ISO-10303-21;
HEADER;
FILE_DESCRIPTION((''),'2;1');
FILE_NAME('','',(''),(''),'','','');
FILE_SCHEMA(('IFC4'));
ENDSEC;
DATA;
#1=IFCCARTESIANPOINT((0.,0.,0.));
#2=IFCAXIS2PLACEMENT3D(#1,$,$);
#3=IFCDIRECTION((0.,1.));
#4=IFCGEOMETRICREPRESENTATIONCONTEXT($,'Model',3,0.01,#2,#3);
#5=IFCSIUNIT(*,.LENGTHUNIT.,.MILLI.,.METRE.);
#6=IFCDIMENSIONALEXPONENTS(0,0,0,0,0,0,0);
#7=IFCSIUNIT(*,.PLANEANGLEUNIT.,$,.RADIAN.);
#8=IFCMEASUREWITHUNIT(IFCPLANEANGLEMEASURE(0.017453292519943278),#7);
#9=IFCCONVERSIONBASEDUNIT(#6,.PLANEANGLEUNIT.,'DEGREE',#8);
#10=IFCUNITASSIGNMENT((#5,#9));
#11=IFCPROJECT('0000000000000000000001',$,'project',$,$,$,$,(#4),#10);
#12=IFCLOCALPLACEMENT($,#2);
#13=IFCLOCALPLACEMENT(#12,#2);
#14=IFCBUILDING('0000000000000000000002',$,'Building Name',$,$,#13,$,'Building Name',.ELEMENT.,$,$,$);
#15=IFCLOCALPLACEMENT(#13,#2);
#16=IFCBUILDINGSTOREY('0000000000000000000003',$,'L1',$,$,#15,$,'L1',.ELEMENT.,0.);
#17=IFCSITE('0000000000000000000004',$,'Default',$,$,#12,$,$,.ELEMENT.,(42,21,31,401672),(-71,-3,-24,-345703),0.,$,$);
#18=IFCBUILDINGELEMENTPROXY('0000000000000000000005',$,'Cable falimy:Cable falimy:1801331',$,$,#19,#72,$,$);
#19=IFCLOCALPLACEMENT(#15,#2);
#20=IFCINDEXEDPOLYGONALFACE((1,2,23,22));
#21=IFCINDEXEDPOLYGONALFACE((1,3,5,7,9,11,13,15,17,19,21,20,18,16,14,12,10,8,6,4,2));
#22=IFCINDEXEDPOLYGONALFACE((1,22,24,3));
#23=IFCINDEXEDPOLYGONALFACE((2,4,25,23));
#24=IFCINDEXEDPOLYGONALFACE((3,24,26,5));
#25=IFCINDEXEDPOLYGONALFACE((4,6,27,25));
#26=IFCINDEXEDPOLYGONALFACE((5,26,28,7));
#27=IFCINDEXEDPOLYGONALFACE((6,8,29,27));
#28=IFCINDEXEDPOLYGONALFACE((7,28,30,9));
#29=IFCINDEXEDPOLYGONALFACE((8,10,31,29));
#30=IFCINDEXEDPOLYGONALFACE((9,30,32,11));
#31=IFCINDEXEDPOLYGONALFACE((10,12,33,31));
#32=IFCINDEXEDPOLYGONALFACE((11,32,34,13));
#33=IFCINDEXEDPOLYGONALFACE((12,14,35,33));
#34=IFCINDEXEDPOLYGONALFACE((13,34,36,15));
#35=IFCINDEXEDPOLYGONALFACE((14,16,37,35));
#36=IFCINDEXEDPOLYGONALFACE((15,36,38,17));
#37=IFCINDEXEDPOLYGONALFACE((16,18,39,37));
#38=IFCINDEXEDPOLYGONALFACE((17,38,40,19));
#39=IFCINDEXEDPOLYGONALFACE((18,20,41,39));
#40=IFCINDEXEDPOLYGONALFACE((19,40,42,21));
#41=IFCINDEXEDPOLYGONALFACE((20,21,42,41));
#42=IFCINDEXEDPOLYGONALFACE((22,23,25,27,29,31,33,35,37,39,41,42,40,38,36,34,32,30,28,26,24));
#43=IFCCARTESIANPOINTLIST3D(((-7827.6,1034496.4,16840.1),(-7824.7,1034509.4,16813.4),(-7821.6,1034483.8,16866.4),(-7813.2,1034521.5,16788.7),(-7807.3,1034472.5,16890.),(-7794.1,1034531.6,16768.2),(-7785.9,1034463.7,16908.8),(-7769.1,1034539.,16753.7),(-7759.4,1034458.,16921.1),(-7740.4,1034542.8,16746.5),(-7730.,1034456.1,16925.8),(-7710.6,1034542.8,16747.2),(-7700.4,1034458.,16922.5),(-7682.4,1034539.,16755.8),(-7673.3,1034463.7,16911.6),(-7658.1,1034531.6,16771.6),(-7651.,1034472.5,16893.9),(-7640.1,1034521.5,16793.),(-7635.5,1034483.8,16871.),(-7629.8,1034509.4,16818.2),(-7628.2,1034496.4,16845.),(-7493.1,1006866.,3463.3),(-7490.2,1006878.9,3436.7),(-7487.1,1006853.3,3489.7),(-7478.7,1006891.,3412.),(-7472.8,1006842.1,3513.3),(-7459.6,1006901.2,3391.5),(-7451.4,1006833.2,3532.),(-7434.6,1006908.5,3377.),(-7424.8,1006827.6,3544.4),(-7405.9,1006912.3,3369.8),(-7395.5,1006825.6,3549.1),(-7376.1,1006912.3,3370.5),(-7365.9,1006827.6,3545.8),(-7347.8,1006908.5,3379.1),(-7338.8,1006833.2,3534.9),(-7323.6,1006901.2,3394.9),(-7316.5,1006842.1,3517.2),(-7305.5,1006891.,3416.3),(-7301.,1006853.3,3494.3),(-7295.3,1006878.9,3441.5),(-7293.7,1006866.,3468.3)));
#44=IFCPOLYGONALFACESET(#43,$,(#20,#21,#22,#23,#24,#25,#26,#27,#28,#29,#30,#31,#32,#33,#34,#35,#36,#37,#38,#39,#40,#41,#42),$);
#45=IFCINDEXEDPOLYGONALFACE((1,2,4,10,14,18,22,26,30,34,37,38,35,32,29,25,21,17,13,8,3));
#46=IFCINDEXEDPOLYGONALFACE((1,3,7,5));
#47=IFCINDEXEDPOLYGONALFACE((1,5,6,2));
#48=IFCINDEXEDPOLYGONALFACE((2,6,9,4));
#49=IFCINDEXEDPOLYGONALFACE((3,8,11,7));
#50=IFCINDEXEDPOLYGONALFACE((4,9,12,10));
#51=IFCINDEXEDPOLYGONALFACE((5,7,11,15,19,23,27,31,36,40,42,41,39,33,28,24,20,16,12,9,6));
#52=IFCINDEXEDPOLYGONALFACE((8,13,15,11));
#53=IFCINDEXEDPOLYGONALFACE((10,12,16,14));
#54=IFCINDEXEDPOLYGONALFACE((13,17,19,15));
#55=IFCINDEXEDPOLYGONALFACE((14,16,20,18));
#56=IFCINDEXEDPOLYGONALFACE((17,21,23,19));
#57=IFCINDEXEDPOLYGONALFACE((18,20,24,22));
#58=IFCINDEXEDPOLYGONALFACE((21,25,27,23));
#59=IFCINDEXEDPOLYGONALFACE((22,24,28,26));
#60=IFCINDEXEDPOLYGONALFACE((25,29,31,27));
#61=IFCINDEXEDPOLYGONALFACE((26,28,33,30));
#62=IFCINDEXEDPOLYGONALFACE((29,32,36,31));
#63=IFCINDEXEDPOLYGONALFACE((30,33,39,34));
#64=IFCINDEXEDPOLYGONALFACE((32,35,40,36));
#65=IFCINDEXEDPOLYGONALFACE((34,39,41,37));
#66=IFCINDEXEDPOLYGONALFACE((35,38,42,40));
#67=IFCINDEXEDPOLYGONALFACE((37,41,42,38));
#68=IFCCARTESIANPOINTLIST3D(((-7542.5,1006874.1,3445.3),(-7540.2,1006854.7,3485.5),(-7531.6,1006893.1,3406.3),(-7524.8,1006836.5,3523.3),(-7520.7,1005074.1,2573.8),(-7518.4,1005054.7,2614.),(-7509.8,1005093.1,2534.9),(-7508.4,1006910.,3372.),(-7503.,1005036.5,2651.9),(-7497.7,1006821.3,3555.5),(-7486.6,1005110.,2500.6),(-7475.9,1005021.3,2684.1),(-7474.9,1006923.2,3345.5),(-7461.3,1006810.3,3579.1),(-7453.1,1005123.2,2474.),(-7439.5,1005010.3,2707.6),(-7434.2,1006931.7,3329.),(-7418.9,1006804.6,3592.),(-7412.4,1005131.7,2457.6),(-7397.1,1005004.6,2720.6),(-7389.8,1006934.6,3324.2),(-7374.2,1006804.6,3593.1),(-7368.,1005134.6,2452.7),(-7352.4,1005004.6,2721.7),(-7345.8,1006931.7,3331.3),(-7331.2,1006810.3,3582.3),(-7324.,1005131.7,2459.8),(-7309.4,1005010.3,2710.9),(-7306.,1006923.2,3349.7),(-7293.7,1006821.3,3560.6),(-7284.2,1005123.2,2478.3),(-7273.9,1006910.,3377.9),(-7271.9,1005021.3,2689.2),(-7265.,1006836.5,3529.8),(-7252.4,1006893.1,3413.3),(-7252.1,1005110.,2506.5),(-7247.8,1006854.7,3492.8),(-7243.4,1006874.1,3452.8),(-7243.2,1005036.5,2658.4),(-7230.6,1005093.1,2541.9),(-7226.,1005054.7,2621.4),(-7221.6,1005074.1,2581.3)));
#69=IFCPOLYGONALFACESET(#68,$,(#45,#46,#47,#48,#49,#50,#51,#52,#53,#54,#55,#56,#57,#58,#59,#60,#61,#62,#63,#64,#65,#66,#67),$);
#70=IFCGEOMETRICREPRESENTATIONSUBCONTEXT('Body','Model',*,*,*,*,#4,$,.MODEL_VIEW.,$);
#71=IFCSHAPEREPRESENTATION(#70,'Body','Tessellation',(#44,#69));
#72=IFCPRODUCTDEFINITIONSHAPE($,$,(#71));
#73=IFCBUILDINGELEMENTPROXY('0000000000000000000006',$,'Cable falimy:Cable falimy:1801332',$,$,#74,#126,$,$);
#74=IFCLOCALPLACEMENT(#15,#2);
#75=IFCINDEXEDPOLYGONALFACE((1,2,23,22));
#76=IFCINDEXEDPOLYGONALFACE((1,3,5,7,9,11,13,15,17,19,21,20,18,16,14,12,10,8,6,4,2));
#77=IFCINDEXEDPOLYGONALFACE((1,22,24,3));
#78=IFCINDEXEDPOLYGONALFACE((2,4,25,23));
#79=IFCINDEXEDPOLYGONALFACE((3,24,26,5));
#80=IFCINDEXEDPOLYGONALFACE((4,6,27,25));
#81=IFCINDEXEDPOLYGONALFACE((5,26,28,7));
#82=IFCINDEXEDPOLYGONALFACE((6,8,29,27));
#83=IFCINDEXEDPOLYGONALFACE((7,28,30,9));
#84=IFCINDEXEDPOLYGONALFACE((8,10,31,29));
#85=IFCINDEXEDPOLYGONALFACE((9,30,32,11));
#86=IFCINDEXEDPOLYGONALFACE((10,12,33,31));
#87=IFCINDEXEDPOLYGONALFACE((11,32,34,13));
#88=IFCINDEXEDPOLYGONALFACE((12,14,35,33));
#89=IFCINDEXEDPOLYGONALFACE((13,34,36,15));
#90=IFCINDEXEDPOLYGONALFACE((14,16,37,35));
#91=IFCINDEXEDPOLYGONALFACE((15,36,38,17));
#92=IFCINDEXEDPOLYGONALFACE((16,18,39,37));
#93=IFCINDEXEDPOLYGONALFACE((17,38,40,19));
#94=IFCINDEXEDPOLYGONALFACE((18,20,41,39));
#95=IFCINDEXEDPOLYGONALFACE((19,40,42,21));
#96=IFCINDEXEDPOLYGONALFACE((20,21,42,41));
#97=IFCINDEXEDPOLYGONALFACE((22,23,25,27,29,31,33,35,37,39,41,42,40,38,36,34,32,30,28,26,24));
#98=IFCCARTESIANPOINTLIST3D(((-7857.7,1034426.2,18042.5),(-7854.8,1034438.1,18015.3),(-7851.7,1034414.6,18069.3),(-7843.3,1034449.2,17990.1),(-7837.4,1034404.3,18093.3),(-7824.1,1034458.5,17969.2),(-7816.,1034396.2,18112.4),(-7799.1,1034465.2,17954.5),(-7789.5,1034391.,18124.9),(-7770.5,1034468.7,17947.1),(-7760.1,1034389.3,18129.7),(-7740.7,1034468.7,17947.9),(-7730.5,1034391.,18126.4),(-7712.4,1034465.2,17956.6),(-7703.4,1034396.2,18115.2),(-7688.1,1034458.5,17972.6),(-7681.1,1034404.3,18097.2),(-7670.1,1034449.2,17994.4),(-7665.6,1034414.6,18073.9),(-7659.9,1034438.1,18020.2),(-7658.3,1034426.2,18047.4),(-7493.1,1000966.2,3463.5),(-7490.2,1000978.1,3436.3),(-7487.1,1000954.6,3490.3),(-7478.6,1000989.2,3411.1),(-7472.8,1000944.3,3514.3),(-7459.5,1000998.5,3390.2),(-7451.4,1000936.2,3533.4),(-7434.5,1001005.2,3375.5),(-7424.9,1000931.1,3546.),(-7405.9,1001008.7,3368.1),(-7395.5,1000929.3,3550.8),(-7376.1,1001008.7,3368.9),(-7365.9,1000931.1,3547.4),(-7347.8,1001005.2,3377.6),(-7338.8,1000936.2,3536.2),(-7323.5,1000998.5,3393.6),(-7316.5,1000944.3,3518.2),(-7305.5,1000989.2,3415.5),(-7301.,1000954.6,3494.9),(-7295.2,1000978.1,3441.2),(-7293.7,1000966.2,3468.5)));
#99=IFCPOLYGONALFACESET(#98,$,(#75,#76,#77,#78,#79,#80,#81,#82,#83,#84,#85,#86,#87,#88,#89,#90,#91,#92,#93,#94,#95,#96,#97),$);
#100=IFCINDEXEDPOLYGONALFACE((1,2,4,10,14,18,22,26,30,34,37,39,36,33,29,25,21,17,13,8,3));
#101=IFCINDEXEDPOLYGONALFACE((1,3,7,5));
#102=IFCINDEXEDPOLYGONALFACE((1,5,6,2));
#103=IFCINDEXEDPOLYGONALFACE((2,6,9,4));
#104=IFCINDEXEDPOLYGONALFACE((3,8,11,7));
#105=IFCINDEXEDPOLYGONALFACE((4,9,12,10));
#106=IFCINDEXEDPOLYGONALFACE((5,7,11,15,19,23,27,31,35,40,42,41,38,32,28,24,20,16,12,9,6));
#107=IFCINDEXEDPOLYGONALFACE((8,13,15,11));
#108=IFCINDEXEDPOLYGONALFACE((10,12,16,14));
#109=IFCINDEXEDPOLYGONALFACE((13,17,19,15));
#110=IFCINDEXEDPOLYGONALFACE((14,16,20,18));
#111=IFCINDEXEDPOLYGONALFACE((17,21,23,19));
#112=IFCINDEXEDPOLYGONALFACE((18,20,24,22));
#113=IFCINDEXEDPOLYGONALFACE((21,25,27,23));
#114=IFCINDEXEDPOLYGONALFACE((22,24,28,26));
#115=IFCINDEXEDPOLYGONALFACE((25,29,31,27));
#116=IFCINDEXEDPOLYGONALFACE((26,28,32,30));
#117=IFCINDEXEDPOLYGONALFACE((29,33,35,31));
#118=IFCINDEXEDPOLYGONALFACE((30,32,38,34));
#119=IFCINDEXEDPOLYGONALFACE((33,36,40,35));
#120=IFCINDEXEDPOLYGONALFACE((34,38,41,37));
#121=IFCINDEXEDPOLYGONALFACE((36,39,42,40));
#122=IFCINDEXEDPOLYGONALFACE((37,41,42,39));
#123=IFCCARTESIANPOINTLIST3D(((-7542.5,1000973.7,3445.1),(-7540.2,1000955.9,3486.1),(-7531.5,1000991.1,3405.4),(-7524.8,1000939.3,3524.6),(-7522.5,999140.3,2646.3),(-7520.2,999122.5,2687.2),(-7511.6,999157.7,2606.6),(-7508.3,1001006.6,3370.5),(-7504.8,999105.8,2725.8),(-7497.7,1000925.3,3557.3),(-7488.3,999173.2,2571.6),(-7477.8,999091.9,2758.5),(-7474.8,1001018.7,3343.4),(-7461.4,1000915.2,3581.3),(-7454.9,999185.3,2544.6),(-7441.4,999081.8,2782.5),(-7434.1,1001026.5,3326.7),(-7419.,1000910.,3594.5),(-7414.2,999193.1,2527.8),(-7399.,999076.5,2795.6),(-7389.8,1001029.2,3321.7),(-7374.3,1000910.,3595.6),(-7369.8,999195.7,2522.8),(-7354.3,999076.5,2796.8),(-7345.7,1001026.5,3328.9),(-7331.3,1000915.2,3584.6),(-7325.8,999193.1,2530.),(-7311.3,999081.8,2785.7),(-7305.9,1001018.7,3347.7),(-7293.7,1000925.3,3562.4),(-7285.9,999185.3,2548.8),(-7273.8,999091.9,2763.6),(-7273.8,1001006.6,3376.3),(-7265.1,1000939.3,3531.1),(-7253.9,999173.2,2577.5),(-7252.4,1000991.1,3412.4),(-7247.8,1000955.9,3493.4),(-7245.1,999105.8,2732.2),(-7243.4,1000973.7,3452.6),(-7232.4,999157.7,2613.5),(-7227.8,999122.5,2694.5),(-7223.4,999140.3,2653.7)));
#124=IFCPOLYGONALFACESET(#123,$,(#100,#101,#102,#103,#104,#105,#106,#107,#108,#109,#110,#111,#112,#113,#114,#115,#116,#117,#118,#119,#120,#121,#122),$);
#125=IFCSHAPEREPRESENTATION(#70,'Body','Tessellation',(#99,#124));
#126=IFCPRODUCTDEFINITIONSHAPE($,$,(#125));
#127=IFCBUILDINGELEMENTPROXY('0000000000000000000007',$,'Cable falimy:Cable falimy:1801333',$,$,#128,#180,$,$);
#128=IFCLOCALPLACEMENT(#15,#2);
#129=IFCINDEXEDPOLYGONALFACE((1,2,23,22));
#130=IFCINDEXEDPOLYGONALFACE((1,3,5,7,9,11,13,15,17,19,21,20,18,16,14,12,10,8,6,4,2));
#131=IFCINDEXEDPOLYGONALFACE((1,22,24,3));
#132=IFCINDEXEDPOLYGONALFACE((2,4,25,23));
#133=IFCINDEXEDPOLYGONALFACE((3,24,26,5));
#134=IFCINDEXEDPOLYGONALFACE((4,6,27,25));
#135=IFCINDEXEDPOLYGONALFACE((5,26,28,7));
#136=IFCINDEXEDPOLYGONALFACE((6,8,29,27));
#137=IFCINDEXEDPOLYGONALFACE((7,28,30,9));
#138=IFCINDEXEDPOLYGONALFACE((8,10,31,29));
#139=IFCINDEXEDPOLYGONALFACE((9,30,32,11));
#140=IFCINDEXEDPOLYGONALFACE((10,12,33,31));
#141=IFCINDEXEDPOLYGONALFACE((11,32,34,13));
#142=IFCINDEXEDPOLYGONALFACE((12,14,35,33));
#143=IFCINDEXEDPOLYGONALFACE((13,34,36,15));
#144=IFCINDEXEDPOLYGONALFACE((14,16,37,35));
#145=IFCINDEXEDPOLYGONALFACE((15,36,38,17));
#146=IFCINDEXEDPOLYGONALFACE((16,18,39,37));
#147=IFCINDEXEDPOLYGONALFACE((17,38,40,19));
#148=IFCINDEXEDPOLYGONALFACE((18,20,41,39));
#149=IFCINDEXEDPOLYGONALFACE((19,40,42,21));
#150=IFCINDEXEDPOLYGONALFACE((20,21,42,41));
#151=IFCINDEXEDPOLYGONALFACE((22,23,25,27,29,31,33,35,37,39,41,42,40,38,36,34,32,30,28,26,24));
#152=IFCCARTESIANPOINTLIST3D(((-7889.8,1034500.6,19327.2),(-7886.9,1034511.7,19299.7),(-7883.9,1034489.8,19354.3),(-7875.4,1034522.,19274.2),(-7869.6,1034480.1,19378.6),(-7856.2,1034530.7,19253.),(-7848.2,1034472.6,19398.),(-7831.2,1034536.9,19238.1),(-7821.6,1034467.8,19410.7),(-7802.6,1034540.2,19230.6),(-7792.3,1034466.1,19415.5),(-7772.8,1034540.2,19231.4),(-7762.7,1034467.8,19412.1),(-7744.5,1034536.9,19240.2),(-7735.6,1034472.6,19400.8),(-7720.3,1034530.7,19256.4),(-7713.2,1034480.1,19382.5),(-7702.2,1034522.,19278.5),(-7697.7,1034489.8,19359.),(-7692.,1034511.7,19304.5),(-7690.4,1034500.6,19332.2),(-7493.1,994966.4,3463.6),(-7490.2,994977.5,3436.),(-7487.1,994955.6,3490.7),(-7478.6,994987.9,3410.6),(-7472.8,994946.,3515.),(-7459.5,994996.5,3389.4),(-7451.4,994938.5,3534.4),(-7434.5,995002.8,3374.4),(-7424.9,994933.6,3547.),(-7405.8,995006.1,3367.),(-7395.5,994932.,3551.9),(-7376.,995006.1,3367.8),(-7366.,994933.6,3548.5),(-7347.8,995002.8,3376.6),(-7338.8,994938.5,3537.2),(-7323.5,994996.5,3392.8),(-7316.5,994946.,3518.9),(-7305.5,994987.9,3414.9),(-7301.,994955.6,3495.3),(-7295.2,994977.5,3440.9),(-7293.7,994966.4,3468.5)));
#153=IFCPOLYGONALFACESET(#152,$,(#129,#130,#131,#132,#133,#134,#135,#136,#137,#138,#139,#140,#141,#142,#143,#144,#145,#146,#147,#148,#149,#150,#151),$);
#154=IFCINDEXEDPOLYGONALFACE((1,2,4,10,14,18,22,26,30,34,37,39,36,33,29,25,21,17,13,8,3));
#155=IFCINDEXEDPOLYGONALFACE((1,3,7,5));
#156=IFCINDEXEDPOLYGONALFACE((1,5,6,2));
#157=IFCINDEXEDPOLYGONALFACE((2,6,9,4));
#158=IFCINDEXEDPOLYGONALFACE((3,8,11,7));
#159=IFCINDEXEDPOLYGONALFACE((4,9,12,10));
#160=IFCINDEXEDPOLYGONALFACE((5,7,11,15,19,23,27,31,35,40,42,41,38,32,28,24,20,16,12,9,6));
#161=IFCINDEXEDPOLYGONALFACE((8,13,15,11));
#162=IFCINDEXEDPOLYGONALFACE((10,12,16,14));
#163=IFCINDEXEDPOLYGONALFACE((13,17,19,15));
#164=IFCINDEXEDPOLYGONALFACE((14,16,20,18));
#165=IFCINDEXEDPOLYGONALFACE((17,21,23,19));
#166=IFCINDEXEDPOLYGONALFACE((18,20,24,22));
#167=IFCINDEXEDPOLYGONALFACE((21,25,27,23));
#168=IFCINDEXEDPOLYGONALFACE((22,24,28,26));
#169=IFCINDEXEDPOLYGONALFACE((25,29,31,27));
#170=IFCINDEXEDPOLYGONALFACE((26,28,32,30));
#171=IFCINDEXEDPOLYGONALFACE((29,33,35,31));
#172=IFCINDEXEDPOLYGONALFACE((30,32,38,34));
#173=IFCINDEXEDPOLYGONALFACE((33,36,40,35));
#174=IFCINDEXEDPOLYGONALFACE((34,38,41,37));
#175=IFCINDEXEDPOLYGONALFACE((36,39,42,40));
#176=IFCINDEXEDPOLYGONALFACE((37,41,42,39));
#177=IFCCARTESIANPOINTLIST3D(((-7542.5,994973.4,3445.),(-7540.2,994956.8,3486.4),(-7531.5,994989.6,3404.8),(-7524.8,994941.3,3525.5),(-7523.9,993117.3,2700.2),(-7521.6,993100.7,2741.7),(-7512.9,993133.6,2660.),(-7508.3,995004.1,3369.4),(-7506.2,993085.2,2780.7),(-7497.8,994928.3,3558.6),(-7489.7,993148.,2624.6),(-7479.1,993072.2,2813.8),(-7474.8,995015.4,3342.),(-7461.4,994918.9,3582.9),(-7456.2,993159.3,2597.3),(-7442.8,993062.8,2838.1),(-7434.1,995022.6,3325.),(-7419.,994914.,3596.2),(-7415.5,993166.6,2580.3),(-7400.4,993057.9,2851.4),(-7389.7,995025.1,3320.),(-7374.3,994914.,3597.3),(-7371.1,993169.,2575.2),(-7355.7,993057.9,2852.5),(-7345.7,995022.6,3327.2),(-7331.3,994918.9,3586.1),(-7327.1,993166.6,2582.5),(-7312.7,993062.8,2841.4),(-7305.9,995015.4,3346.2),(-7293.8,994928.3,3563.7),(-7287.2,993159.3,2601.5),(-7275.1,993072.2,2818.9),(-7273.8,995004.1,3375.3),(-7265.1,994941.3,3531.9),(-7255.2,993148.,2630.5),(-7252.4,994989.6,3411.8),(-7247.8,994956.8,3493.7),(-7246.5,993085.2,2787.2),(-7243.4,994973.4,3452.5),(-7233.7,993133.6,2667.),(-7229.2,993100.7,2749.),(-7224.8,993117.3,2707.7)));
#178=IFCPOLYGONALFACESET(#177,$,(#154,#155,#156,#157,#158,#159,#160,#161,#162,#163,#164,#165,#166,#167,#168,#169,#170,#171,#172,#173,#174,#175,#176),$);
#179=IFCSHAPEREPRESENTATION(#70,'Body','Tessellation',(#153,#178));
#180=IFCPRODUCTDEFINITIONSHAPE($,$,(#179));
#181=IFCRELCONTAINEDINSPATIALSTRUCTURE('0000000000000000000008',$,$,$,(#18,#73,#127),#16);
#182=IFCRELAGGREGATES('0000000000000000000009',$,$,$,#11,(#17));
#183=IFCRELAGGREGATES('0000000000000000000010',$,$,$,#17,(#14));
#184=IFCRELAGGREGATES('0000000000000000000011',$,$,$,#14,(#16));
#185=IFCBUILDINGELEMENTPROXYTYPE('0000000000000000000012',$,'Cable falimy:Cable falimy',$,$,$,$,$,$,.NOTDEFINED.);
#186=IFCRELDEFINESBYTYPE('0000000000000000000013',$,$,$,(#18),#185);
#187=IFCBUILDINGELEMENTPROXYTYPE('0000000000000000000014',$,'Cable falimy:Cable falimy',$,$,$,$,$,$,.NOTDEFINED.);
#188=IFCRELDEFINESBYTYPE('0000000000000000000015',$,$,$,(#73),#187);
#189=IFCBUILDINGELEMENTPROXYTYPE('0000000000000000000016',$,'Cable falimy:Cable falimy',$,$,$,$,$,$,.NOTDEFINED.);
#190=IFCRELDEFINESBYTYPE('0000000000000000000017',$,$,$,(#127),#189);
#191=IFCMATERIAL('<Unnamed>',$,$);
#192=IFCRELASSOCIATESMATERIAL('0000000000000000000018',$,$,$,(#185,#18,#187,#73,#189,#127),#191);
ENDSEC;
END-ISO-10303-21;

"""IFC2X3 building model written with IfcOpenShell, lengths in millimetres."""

from ifc_helpers import new_model, entity, si_unit, converted_unit, direction, frame, frame_2d, origin, place, context, subcontext, project, spatial, circle, extrude, source, transform, mapped, material, type_object, type_shapes, element, save


model = new_model("IFC2X3")

# Units and contexts
model_context = context("Model", 3, precision=0.01, world=origin(), true_north=direction((0.0, 1.0)))
body_context = subcontext(model_context, "Body", "Model", "MODEL_VIEW")
ifc_project = project(units=[si_unit("LENGTHUNIT", "METRE", prefix="MILLI"), converted_unit("PLANEANGLEUNIT", "DEGREE", entity("IfcPlaneAngleMeasure", 0.017453292519943278), si_unit("PLANEANGLEUNIT", "RADIAN"), dimensions=[0, 0, 0, 0, 0, 0, 0])], contexts=[model_context])

# Site, building, storey
site_placement = place(None, origin())
site = spatial("IfcSite", under=ifc_project, at=site_placement, Name="Default", CompositionType="ELEMENT", RefLatitude=(42, 21, 31, 401672), RefLongitude=(-71, -3, -24, -345703), RefElevation=0.0)
building_placement = place(site_placement, origin())
building = spatial("IfcBuilding", under=site, at=building_placement, Name="Building Name", LongName="Building Name", CompositionType="ELEMENT")
storey_placement = place(building_placement, origin())
storey = spatial("IfcBuildingStorey", under=building, at=storey_placement, Name="L1", LongName="L1", CompositionType="ELEMENT", Elevation=0.0)

# Shared definitions
ifc_material = material(Name="<Unnamed>")

# Building element proxies
building_element_proxy_type_1 = type_object("IfcBuildingElementProxyType", Name="Cable falimy:Cable falimy", PredefinedType="NOTDEFINED", material=ifc_material)
shared_shape_1 = source(origin(), body_context, "Body", "SweptSolid", [
    extrude(circle(Radius=100.0, at=frame_2d((0.0, 0.0), x_axis=(1.0, 0.0))), frame((0.0, 0.0, 0.0), z_axis=(0.900015, 0.0, 0.43586), x_axis=(-0.43586, 0.0, 0.900015)), (0.0, 0.0, 1.0), 30700.0),
    extrude(circle(Radius=150.0, at=frame_2d((0.0, 0.0), x_axis=(1.0, 0.0))), frame((-1800.0, 0.0, -871.7), z_axis=(0.900015, 0.0, 0.43586), x_axis=(0.43586, 0.0, -0.900015)), (0.0, 0.0, 1.0), 2000.0),
])
type_shapes(building_element_proxy_type_1, [shared_shape_1])
proxy_1_placement = place(storey_placement, frame((-7393.2, 1006869.2, 3459.1), z_axis=(-0.025001, 0.0, 0.999687), x_axis=(0.0, 1.0, 0.0)))
element("IfcBuildingElementProxy", 1, at=proxy_1_placement, inside=storey, type_object=building_element_proxy_type_1, material=ifc_material, Name="Cable falimy:Cable falimy:1801331", context=body_context, shape_type="MappedRepresentation", body=[
    mapped(shared_shape_1, transform((0.0, 0.0, 0.0), scale=1.0)),
])
building_element_proxy_type_2 = type_object("IfcBuildingElementProxyType", Name="Cable falimy:Cable falimy", PredefinedType="NOTDEFINED", material=ifc_material)
shared_shape_2 = source(origin(), body_context, "Body", "SweptSolid", [
    extrude(circle(Radius=100.0, at=frame_2d((0.0, 0.0), x_axis=(1.0, 0.0))), frame((0.0, 0.0, 0.0), z_axis=(0.916712, 0.0, 0.399549), x_axis=(-0.399549, 0.0, 0.916712)), (0.0, 0.0, 1.0), 36500.0),
    extrude(circle(Radius=150.0, at=frame_2d((0.0, 0.0), x_axis=(1.0, 0.0))), frame((-1833.4, 0.0, -799.1), z_axis=(0.916712, 0.0, 0.399549), x_axis=(0.399549, 0.0, -0.916712)), (0.0, 0.0, 1.0), 2000.0),
])
type_shapes(building_element_proxy_type_2, [shared_shape_2])
proxy_2_placement = place(storey_placement, frame((-7393.2, 1000969.2, 3459.1), z_axis=(-0.025001, 0.0, 0.999687), x_axis=(0.0, 1.0, 0.0)))
element("IfcBuildingElementProxy", 2, at=proxy_2_placement, inside=storey, type_object=building_element_proxy_type_2, material=ifc_material, Name="Cable falimy:Cable falimy:1801332", context=body_context, shape_type="MappedRepresentation", body=[
    mapped(shared_shape_2, transform((0.0, 0.0, 0.0), scale=1.0)),
])
building_element_proxy_type_3 = type_object("IfcBuildingElementProxyType", Name="Cable falimy:Cable falimy", PredefinedType="NOTDEFINED", material=ifc_material)
shared_shape_3 = source(origin(), body_context, "Body", "SweptSolid", [
    extrude(circle(Radius=100.0, at=frame_2d((0.0, 0.0), x_axis=(1.0, 0.0))), frame((0.0, 0.0, 0.0), z_axis=(0.928031, 0.0, 0.372502), x_axis=(-0.372502, 0.0, 0.928031)), (0.0, 0.0, 1.0), 42600.0),
    extrude(circle(Radius=150.0, at=frame_2d((0.0, 0.0), x_axis=(1.0, 0.0))), frame((-1856.1, 0.0, -745.0), z_axis=(0.928031, 0.0, 0.372502), x_axis=(0.372502, 0.0, -0.928031)), (0.0, 0.0, 1.0), 2000.0),
])
type_shapes(building_element_proxy_type_3, [shared_shape_3])
proxy_3_placement = place(storey_placement, frame((-7393.2, 994969.2, 3459.1), z_axis=(-0.025001, 0.0, 0.999687), x_axis=(0.0, 1.0, 0.0)))
element("IfcBuildingElementProxy", 3, at=proxy_3_placement, inside=storey, type_object=building_element_proxy_type_3, material=ifc_material, Name="Cable falimy:Cable falimy:1801333", context=body_context, shape_type="MappedRepresentation", body=[
    mapped(shared_shape_3, transform((0.0, 0.0, 0.0), scale=1.0)),
])

save(model, "model.ifc")
